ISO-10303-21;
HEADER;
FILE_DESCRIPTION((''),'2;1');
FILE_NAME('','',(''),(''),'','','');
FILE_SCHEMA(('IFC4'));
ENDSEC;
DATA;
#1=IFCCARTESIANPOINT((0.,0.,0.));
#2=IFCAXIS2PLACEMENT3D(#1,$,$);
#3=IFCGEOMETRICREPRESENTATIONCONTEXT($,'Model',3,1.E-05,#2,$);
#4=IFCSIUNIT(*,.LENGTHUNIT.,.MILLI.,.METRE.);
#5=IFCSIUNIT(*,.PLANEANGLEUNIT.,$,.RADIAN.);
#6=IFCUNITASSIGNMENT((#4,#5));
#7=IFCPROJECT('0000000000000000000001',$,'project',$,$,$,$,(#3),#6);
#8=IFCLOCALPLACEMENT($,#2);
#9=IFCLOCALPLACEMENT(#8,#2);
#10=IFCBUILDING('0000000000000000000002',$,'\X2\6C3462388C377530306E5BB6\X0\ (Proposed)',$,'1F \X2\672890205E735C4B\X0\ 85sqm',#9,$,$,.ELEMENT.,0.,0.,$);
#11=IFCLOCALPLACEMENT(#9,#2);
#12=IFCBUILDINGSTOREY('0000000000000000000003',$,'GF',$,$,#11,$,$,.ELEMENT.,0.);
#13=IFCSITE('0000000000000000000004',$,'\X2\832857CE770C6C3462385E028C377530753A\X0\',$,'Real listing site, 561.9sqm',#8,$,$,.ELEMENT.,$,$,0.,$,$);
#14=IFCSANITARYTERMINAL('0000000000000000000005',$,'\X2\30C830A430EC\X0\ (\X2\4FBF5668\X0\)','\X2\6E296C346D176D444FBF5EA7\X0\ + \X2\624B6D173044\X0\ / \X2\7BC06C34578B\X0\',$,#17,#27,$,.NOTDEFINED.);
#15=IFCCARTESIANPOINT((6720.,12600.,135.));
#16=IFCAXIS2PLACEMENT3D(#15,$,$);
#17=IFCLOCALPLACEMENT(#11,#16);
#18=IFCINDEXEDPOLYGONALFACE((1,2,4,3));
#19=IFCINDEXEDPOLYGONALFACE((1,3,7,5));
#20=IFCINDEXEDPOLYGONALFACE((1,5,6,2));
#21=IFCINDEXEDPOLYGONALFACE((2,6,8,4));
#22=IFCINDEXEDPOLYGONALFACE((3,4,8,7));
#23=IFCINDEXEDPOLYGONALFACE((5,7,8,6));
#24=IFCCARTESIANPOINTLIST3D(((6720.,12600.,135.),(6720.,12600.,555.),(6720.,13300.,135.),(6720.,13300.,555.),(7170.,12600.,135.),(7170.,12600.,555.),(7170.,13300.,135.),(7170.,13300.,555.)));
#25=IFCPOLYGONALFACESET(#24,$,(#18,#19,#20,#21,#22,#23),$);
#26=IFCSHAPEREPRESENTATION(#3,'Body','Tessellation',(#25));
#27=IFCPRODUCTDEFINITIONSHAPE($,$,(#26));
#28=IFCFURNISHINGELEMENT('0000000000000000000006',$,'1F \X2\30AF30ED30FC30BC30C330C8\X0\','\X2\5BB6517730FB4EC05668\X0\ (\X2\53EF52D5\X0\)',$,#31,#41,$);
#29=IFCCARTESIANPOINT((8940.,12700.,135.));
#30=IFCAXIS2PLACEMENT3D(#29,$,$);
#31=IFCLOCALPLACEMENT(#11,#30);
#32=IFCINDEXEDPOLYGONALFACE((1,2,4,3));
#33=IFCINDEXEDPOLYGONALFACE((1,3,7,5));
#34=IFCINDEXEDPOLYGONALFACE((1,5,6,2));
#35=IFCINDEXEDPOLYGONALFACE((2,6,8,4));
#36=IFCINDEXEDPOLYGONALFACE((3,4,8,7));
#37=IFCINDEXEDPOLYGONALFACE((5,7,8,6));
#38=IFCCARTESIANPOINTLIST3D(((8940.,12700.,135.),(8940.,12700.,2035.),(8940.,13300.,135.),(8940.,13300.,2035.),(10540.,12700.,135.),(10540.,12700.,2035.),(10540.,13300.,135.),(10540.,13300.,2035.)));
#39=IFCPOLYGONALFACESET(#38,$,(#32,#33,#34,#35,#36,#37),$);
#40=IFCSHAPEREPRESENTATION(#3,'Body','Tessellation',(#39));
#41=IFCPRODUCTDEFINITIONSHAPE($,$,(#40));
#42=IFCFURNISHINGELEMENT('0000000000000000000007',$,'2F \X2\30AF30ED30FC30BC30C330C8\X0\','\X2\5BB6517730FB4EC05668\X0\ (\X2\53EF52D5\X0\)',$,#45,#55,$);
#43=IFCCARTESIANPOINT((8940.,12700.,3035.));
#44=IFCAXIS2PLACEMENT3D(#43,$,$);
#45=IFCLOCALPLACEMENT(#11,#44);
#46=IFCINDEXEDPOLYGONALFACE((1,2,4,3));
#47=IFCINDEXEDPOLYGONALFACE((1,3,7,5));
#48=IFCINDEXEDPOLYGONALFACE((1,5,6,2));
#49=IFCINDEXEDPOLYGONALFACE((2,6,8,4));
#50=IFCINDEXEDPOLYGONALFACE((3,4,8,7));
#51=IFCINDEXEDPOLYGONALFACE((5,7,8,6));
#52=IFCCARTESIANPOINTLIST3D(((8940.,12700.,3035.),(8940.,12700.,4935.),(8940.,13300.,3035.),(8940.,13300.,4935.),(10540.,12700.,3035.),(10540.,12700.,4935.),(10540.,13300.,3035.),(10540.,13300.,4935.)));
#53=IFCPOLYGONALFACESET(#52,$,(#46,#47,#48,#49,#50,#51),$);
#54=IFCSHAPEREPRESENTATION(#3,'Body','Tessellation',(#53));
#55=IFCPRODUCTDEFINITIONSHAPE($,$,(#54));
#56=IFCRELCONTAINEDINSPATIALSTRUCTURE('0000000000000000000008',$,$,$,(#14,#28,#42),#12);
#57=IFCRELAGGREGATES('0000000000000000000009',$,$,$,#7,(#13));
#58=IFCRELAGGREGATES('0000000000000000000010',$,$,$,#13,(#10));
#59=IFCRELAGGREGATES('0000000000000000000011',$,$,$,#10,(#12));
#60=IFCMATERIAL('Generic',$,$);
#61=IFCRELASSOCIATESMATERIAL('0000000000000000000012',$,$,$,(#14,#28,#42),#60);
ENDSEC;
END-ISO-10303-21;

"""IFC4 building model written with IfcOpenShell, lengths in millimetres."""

from ifc_helpers import new_model, si_unit, frame, frame_2d, origin, place, context, project, spatial, rectangle, extrude, material, element, save


model = new_model("IFC4")

# Units and contexts
model_context = context("Model", 3, precision=1e-05, world=origin())
ifc_project = project(units=[si_unit("LENGTHUNIT", "METRE", prefix="MILLI"), si_unit("PLANEANGLEUNIT", "RADIAN")], contexts=[model_context])

# Site, building, storey
site_placement = place(None, origin())
site = spatial("IfcSite", under=ifc_project, at=site_placement, Name="茨城県水戸市谷田町", ObjectType="Real listing site, 561.9sqm", CompositionType="ELEMENT", RefElevation=0.0)
building_placement = place(site_placement, origin())
building = spatial("IfcBuilding", under=site, at=building_placement, Name="水戸谷田の家 (Proposed)", ObjectType="1F 木造平屋 85sqm", CompositionType="ELEMENT", ElevationOfRefHeight=0.0, ElevationOfTerrain=0.0)
storey_placement = place(building_placement, origin())
storey = spatial("IfcBuildingStorey", under=building, at=storey_placement, Name="GF", CompositionType="ELEMENT", Elevation=0.0)

# Sanitary terminal
ifc_material_1 = material(Name="Generic")
sanitary_terminal_1_placement = place(storey_placement, frame((6720.0, 12600.0, 135.0)))
element("IfcSanitaryTerminal", 1, at=sanitary_terminal_1_placement, inside=storey, material=ifc_material_1, Name="トイレ (便器)", Description="温水洗浄便座 + 手洗い / 節水型", PredefinedType="NOTDEFINED", context=model_context, shape_type="SweptSolid", body=[
    extrude(rectangle(XDim=450.0, YDim=700.0, at=frame_2d((225.0, 350.0))), frame((6720.0, 12600.0, 135.0)), (0.0, 0.0, 1.0), 420.0),
])

# Furnishing elements
furnishing_1_placement = place(storey_placement, frame((8940.0, 12700.0, 135.0)))
element("IfcFurnishingElement", 2, at=furnishing_1_placement, inside=storey, material=ifc_material_1, Name="1F クローゼット", Description="家具・什器 (可動)", context=model_context, shape_type="SweptSolid", body=[
    extrude(rectangle(XDim=1600.0, YDim=600.0, at=frame_2d((800.0, 300.0))), frame((8940.0, 12700.0, 135.0)), (0.0, 0.0, 1.0), 1900.0),
])
furnishing_2_placement = place(storey_placement, frame((8940.0, 12700.0, 3035.0)))
element("IfcFurnishingElement", 3, at=furnishing_2_placement, inside=storey, material=ifc_material_1, Name="2F クローゼット", Description="家具・什器 (可動)", context=model_context, shape_type="SweptSolid", body=[
    extrude(rectangle(XDim=1600.0, YDim=600.0, at=frame_2d((800.0, 300.0))), frame((8940.0, 12700.0, 3035.0)), (0.0, 0.0, 1.0), 1900.0),
])

save(model, "model.ifc")
